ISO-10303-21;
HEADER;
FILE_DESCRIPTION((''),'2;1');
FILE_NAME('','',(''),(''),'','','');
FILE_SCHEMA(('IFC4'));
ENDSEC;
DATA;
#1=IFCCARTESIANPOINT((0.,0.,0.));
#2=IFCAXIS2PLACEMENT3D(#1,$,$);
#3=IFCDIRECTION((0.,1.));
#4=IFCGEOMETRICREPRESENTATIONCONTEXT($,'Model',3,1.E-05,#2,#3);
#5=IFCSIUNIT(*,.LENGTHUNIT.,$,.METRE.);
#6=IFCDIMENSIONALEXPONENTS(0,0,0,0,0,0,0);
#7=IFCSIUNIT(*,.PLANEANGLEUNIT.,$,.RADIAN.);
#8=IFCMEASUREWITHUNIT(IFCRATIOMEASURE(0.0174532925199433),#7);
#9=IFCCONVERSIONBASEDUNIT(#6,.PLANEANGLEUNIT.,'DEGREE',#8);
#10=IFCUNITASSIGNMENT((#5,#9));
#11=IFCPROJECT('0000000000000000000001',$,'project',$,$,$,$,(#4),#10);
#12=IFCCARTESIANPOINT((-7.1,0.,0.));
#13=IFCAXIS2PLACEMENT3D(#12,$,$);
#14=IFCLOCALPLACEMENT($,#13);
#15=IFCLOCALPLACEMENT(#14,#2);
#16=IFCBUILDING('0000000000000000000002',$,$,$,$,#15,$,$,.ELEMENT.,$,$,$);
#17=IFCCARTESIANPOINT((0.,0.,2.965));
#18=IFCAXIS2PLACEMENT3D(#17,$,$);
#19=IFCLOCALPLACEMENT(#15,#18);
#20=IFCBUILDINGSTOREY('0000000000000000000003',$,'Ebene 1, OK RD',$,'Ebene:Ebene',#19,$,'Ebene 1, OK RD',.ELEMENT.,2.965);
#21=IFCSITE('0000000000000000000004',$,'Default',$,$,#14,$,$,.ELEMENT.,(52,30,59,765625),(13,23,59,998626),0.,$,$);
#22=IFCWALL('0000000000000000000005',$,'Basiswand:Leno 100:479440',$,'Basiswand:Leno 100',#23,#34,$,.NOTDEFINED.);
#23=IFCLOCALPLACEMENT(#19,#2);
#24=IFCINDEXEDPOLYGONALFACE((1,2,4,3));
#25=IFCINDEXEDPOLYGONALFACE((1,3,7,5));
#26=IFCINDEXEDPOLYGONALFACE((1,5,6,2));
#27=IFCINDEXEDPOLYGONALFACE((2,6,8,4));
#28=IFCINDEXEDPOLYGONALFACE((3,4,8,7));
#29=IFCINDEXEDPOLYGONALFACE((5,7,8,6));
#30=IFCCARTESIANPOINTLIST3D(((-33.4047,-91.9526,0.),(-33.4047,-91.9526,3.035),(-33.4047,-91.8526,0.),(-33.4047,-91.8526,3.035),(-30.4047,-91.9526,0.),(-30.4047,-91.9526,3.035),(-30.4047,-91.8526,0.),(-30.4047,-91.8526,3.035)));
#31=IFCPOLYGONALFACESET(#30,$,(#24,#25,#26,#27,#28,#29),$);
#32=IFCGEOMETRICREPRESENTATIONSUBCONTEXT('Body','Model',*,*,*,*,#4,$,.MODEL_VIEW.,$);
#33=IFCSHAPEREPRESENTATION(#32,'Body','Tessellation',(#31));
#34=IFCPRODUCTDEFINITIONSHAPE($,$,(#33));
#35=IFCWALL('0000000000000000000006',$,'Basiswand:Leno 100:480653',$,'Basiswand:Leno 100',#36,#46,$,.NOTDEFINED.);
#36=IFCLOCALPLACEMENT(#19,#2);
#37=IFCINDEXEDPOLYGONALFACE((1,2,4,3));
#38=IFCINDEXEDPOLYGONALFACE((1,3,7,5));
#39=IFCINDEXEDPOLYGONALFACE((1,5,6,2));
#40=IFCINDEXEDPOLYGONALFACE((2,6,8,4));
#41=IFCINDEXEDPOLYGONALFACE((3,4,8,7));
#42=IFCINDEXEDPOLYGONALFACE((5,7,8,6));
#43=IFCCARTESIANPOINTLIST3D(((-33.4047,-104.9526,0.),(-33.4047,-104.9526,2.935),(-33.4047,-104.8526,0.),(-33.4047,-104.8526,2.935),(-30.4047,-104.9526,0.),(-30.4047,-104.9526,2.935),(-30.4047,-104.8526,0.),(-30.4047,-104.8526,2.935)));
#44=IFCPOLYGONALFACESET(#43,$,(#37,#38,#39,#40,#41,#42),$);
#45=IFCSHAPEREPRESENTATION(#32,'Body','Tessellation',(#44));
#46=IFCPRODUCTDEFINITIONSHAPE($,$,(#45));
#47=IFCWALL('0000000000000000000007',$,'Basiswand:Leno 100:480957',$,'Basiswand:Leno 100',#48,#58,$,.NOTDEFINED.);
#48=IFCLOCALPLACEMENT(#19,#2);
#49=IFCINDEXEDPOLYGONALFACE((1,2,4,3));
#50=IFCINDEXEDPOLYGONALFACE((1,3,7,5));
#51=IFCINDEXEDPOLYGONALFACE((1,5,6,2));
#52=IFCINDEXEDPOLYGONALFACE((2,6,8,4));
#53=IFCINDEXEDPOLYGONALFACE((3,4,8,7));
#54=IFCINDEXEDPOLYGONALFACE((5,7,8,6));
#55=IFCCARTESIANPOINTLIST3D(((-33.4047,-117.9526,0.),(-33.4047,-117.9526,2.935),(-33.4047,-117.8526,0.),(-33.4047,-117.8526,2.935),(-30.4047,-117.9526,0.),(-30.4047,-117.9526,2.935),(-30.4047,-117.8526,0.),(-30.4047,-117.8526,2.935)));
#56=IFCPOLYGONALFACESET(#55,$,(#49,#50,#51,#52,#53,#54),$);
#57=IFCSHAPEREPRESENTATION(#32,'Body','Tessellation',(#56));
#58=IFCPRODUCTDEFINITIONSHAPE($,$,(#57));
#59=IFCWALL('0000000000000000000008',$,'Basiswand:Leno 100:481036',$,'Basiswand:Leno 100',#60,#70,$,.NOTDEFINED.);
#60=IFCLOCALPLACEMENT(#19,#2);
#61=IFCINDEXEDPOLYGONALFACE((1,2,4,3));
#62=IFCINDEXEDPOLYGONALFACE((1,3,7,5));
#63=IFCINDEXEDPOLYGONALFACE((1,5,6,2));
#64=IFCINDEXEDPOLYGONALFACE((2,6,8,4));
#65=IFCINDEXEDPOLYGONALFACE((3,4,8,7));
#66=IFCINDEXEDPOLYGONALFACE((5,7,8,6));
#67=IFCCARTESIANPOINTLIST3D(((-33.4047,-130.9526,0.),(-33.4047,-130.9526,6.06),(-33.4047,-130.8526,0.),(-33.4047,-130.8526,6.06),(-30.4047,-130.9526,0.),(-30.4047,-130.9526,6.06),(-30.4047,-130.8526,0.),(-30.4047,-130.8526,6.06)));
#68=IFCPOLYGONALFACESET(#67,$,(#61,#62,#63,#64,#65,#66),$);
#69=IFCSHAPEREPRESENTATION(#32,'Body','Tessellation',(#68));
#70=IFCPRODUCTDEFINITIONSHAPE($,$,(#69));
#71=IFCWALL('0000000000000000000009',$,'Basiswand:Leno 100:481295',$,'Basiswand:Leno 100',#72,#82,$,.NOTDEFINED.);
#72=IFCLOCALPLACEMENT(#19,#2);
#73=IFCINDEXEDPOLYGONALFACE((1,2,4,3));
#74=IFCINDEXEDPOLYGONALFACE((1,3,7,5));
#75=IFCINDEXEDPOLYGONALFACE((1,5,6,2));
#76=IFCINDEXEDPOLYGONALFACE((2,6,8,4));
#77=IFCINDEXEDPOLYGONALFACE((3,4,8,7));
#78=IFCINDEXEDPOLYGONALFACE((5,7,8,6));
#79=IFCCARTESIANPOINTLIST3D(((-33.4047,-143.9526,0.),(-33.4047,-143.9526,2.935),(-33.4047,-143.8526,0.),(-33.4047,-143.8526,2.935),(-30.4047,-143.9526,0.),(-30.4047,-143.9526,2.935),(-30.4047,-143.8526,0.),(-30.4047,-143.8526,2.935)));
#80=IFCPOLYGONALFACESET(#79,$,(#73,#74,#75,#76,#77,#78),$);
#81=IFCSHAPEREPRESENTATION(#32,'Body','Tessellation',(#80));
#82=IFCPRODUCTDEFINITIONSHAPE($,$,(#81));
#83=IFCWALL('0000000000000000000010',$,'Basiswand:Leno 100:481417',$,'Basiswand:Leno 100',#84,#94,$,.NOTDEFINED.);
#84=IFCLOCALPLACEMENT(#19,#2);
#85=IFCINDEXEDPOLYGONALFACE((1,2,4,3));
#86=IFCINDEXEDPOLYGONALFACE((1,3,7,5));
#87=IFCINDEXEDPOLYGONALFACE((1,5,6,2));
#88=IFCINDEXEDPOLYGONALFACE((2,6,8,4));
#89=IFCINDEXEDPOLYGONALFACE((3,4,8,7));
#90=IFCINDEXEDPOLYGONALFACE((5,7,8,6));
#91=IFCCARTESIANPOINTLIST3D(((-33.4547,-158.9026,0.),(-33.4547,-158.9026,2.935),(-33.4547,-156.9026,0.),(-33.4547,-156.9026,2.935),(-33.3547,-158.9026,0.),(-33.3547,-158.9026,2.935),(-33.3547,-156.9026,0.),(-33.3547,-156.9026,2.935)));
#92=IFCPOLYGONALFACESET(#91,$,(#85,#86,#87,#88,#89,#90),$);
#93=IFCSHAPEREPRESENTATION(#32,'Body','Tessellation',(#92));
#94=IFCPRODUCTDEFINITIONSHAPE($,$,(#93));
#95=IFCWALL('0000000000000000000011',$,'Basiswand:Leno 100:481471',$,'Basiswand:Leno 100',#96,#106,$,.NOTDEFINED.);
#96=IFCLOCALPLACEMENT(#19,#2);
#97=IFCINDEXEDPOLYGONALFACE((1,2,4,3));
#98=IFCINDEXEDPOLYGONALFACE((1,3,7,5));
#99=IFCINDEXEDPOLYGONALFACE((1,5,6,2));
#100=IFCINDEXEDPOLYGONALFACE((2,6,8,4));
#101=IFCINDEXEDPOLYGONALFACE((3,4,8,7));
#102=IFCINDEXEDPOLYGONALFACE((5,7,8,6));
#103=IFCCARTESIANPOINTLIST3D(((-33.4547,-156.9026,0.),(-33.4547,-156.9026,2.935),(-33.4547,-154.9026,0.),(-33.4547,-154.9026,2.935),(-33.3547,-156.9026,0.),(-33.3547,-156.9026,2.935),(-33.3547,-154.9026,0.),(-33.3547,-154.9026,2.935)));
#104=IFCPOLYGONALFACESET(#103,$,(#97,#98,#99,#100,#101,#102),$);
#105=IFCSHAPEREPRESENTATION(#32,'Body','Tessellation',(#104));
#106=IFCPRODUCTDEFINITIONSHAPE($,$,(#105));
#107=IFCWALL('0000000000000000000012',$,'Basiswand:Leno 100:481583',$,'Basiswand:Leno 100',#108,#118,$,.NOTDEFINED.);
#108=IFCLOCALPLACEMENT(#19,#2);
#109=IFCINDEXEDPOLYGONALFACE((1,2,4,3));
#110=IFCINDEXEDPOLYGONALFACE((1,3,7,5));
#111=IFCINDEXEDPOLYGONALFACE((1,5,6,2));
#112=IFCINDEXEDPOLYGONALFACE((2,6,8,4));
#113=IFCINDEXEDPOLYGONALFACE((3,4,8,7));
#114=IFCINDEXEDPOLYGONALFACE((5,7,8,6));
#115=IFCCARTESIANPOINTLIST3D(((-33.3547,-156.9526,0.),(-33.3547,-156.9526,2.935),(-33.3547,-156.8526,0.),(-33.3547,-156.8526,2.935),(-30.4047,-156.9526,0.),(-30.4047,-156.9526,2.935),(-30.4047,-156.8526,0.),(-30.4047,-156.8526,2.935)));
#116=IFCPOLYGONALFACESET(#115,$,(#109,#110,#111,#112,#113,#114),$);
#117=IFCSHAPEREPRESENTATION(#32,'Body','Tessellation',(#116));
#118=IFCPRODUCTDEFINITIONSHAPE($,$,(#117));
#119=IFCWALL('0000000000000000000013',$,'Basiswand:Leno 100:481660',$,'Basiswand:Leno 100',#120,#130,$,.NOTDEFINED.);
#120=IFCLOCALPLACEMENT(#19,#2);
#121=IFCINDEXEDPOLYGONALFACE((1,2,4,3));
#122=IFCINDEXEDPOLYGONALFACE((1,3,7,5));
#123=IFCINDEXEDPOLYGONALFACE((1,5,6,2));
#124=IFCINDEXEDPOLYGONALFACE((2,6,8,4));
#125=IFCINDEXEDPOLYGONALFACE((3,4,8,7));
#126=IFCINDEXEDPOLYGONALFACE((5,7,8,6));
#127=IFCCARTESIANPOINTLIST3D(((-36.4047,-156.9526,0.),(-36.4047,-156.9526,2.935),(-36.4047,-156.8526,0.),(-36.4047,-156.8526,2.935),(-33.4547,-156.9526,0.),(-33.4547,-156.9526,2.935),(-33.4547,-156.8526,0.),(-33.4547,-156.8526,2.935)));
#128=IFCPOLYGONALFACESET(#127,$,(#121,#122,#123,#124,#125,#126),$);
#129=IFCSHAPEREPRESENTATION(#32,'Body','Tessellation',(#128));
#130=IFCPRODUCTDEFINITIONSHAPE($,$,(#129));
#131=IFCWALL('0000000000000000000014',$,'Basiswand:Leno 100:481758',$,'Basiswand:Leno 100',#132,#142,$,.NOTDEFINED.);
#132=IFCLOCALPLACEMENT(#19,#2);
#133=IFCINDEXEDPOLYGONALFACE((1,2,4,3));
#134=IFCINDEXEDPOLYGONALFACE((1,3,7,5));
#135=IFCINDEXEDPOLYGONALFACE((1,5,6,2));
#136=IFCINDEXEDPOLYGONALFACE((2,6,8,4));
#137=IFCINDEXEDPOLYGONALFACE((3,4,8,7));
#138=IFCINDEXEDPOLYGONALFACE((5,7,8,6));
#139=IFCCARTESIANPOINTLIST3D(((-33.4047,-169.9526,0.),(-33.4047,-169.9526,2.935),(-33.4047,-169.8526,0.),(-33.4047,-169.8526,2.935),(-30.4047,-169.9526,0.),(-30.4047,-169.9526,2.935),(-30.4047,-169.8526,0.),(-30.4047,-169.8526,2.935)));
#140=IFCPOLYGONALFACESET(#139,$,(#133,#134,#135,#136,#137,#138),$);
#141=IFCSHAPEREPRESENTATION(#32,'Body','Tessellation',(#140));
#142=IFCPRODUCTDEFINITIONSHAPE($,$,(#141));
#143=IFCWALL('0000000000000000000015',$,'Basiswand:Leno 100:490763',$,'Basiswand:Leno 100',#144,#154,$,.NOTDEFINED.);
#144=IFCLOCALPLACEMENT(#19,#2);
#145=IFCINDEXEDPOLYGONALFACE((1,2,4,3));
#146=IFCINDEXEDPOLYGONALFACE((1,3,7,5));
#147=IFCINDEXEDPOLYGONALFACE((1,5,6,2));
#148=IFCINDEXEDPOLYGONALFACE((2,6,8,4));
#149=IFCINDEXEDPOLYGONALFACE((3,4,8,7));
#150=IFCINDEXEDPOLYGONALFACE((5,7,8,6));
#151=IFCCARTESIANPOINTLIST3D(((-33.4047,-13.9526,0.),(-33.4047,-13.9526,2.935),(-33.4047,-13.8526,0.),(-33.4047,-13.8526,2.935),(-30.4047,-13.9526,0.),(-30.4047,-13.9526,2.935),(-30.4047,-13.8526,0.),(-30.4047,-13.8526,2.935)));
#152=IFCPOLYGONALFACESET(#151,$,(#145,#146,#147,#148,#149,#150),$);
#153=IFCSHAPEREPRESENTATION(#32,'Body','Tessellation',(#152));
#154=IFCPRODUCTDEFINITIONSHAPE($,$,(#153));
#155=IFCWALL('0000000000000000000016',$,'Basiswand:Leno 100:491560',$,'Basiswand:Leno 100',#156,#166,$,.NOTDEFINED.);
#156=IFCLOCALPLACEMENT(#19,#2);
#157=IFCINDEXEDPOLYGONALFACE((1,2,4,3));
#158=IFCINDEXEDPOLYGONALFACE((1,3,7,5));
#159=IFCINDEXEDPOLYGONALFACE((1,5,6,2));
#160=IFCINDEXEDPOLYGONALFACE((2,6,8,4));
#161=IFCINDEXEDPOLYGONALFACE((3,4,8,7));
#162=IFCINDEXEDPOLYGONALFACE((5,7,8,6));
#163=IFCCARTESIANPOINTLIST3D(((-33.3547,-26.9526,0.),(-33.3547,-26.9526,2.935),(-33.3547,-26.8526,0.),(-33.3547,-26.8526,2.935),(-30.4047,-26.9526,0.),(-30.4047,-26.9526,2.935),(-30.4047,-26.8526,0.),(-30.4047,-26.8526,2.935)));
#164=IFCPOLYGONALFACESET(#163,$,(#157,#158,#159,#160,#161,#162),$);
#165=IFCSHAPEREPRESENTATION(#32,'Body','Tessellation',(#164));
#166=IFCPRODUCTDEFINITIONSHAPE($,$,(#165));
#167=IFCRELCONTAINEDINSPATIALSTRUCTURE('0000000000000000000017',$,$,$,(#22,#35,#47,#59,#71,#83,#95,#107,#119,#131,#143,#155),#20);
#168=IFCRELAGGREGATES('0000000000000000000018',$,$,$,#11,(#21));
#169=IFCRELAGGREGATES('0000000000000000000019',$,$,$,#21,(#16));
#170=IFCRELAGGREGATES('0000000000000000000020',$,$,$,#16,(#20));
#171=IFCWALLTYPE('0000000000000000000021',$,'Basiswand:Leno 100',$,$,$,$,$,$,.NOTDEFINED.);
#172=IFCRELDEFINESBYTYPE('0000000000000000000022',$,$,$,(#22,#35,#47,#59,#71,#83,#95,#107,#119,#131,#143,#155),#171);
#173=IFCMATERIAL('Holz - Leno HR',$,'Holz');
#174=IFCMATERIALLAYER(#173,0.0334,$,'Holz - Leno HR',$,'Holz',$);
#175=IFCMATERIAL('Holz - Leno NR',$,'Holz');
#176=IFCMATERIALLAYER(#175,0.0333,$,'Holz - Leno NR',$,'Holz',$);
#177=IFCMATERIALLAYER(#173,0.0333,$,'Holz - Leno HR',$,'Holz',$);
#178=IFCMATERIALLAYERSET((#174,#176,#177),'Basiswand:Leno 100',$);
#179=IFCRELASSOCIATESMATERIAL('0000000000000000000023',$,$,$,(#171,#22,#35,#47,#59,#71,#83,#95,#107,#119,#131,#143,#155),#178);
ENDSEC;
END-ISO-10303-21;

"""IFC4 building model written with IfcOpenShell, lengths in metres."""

from ifc_helpers import new_model, entity, si_unit, converted_unit, direction, frame, origin, place, context, subcontext, project, spatial, indexed_curve, outline, extrude, material, layer, layer_set, type_object, element, save


model = new_model("IFC4")

# Units and contexts
model_context = context("Model", 3, precision=1e-05, world=origin(), true_north=direction((0.0, 1.0)))
body_context = subcontext(model_context, "Body", "Model", "MODEL_VIEW")
ifc_project = project(units=[si_unit("LENGTHUNIT", "METRE"), converted_unit("PLANEANGLEUNIT", "DEGREE", entity("IfcRatioMeasure", 0.0174532925199433), si_unit("PLANEANGLEUNIT", "RADIAN"), dimensions=[0, 0, 0, 0, 0, 0, 0])], contexts=[model_context])

# Site, building, storey
site_placement = place(None, frame((-7.1, 0.0, 0.0)))
site = spatial("IfcSite", under=ifc_project, at=site_placement, Name="Default", CompositionType="ELEMENT", RefLatitude=(52, 30, 59, 765625), RefLongitude=(13, 23, 59, 998626), RefElevation=0.0)
building_placement = place(site_placement, origin())
building = spatial("IfcBuilding", under=site, at=building_placement, CompositionType="ELEMENT")
storey_placement = place(building_placement, frame((0.0, 0.0, 2.965)))
storey = spatial("IfcBuildingStorey", under=building, at=storey_placement, Name="Ebene 1, OK RD", ObjectType="Ebene:Ebene", LongName="Ebene 1, OK RD", CompositionType="ELEMENT", Elevation=2.965)

# Walls
ifc_material_1 = material(Name="Holz - Leno HR", Category="Holz")
ifc_layer_1 = layer(ifc_material_1, 0.0334, Name="Holz - Leno HR", Category="Holz")
ifc_material_2 = material(Name="Holz - Leno NR", Category="Holz")
ifc_layer_2 = layer(ifc_material_2, 0.0333, Name="Holz - Leno NR", Category="Holz")
ifc_layer_3 = layer(ifc_material_1, 0.0333, Name="Holz - Leno HR", Category="Holz")
ifc_layer_set = layer_set([ifc_layer_1, ifc_layer_2, ifc_layer_3], Name="Basiswand:Leno 100")
wall_type = type_object("IfcWallType", Name="Basiswand:Leno 100", PredefinedType="NOTDEFINED", material=ifc_layer_set)
wall_1_placement = place(storey_placement, frame((-30.4047, -91.9026, 0.0), z_axis=(0.0, 0.0, 1.0), x_axis=(-1.0, 0.0, 0.0)))
element("IfcWall", 1, at=wall_1_placement, inside=storey, type_object=wall_type, material=ifc_layer_set, Name="Basiswand:Leno 100:479440", ObjectType="Basiswand:Leno 100", PredefinedType="NOTDEFINED", context=body_context, shape_type="SweptSolid", body=[
    extrude(outline(indexed_curve([(3.0, 0.05), (0.0, 0.05), (0.0, -0.05), (3.0, -0.05), (3.0, 0.05)], self_intersect=False)), origin(), (0.0, 0.0, 1.0), 3.035),
])
for number, where, z_axis, x_axis, name in (
    (2, (-30.4047, -104.9026, 0.0), (0.0, 0.0, 1.0), (-1.0, 0.0, 0.0), "Basiswand:Leno 100:480653"),
    (3, (-30.4047, -117.9026, 0.0), (0.0, 0.0, 1.0), (-1.0, 0.0, 0.0), "Basiswand:Leno 100:480957"),
):
    element("IfcWall", number, at=place(storey_placement, frame(where, z_axis=z_axis, x_axis=x_axis)), inside=storey, type_object=wall_type, material=ifc_layer_set, Name=name, ObjectType="Basiswand:Leno 100", PredefinedType="NOTDEFINED", context=body_context, shape_type="SweptSolid", body=[
        extrude(outline(indexed_curve([(3.0, 0.05), (0.0, 0.05), (0.0, -0.05), (3.0, -0.05), (3.0, 0.05)], self_intersect=False)), origin(), (0.0, 0.0, 1.0), 2.935),
    ])
wall_2_placement = place(storey_placement, frame((-30.4047, -130.9026, 0.0), z_axis=(0.0, 0.0, 1.0), x_axis=(-1.0, 0.0, 0.0)))
element("IfcWall", 4, at=wall_2_placement, inside=storey, type_object=wall_type, material=ifc_layer_set, Name="Basiswand:Leno 100:481036", ObjectType="Basiswand:Leno 100", PredefinedType="NOTDEFINED", context=body_context, shape_type="SweptSolid", body=[
    extrude(outline(indexed_curve([(3.0, 0.05), (0.0, 0.05), (0.0, -0.05), (3.0, -0.05), (3.0, 0.05)], self_intersect=False)), origin(), (0.0, 0.0, 1.0), 6.06),
])
wall_3_placement = place(storey_placement, frame((-30.4047, -143.9026, 0.0), z_axis=(0.0, 0.0, 1.0), x_axis=(-1.0, 0.0, 0.0)))
element("IfcWall", 5, at=wall_3_placement, inside=storey, type_object=wall_type, material=ifc_layer_set, Name="Basiswand:Leno 100:481295", ObjectType="Basiswand:Leno 100", PredefinedType="NOTDEFINED", context=body_context, shape_type="SweptSolid", body=[
    extrude(outline(indexed_curve([(3.0, 0.05), (0.0, 0.05), (0.0, -0.05), (3.0, -0.05), (3.0, 0.05)], self_intersect=False)), origin(), (0.0, 0.0, 1.0), 2.935),
])
wall_4_placement = place(storey_placement, frame((-33.4047, -158.9026, 0.0), z_axis=(0.0, 0.0, 1.0), x_axis=(0.0, 1.0, 0.0)))
element("IfcWall", 6, at=wall_4_placement, inside=storey, type_object=wall_type, material=ifc_layer_set, Name="Basiswand:Leno 100:481417", ObjectType="Basiswand:Leno 100", PredefinedType="NOTDEFINED", context=body_context, shape_type="SweptSolid", body=[
    extrude(outline(indexed_curve([(2.0, 0.05), (0.0, 0.05), (0.0, -0.05), (2.0, -0.05), (2.0, 0.05)], self_intersect=False)), origin(), (0.0, 0.0, 1.0), 2.935),
])
wall_5_placement = place(storey_placement, frame((-33.4047, -154.9026, 0.0), z_axis=(0.0, 0.0, 1.0), x_axis=(0.0, -1.0, 0.0)))
element("IfcWall", 7, at=wall_5_placement, inside=storey, type_object=wall_type, material=ifc_layer_set, Name="Basiswand:Leno 100:481471", ObjectType="Basiswand:Leno 100", PredefinedType="NOTDEFINED", context=body_context, shape_type="SweptSolid", body=[
    extrude(outline(indexed_curve([(2.0, 0.05), (0.0, 0.05), (0.0, -0.05), (2.0, -0.05), (2.0, 0.05)], self_intersect=False)), origin(), (0.0, 0.0, 1.0), 2.935),
])
wall_6_placement = place(storey_placement, frame((-30.4047, -156.9026, 0.0), z_axis=(0.0, 0.0, 1.0), x_axis=(-1.0, 0.0, 0.0)))
element("IfcWall", 8, at=wall_6_placement, inside=storey, type_object=wall_type, material=ifc_layer_set, Name="Basiswand:Leno 100:481583", ObjectType="Basiswand:Leno 100", PredefinedType="NOTDEFINED", context=body_context, shape_type="SweptSolid", body=[
    extrude(outline(indexed_curve([(2.95, 0.05), (0.0, 0.05), (0.0, -0.05), (2.95, -0.05), (2.95, 0.05)], self_intersect=False)), origin(), (0.0, 0.0, 1.0), 2.935),
])
wall_7_placement = place(storey_placement, frame((-36.4047, -156.9026, 0.0)))
element("IfcWall", 9, at=wall_7_placement, inside=storey, type_object=wall_type, material=ifc_layer_set, Name="Basiswand:Leno 100:481660", ObjectType="Basiswand:Leno 100", PredefinedType="NOTDEFINED", context=body_context, shape_type="SweptSolid", body=[
    extrude(outline(indexed_curve([(2.95, 0.05), (0.0, 0.05), (0.0, -0.05), (2.95, -0.05), (2.95, 0.05)], self_intersect=False)), origin(), (0.0, 0.0, 1.0), 2.935),
])
wall_8_placement = place(storey_placement, frame((-30.4047, -169.9026, 0.0), z_axis=(0.0, 0.0, 1.0), x_axis=(-1.0, 0.0, 0.0)))
element("IfcWall", 10, at=wall_8_placement, inside=storey, type_object=wall_type, material=ifc_layer_set, Name="Basiswand:Leno 100:481758", ObjectType="Basiswand:Leno 100", PredefinedType="NOTDEFINED", context=body_context, shape_type="SweptSolid", body=[
    extrude(outline(indexed_curve([(3.0, 0.05), (0.0, 0.05), (0.0, -0.05), (3.0, -0.05), (3.0, 0.05)], self_intersect=False)), origin(), (0.0, 0.0, 1.0), 2.935),
])
wall_9_placement = place(storey_placement, frame((-33.4047, -13.9026, 0.0)))
element("IfcWall", 11, at=wall_9_placement, inside=storey, type_object=wall_type, material=ifc_layer_set, Name="Basiswand:Leno 100:490763", ObjectType="Basiswand:Leno 100", PredefinedType="NOTDEFINED", context=body_context, shape_type="SweptSolid", body=[
    extrude(outline(indexed_curve([(3.0, 0.05), (0.0, 0.05), (0.0, -0.05), (3.0, -0.05), (3.0, 0.05)], self_intersect=False)), origin(), (0.0, 0.0, 1.0), 2.935),
])
wall_10_placement = place(storey_placement, frame((-30.4047, -26.9026, 0.0), z_axis=(0.0, 0.0, 1.0), x_axis=(-1.0, 0.0, 0.0)))
element("IfcWall", 12, at=wall_10_placement, inside=storey, type_object=wall_type, material=ifc_layer_set, Name="Basiswand:Leno 100:491560", ObjectType="Basiswand:Leno 100", PredefinedType="NOTDEFINED", context=body_context, shape_type="SweptSolid", body=[
    extrude(outline(indexed_curve([(2.95, 0.05), (0.0, 0.05), (0.0, -0.05), (2.95, -0.05), (2.95, 0.05)], self_intersect=False)), origin(), (0.0, 0.0, 1.0), 2.935),
])

save(model, "model.ifc")
